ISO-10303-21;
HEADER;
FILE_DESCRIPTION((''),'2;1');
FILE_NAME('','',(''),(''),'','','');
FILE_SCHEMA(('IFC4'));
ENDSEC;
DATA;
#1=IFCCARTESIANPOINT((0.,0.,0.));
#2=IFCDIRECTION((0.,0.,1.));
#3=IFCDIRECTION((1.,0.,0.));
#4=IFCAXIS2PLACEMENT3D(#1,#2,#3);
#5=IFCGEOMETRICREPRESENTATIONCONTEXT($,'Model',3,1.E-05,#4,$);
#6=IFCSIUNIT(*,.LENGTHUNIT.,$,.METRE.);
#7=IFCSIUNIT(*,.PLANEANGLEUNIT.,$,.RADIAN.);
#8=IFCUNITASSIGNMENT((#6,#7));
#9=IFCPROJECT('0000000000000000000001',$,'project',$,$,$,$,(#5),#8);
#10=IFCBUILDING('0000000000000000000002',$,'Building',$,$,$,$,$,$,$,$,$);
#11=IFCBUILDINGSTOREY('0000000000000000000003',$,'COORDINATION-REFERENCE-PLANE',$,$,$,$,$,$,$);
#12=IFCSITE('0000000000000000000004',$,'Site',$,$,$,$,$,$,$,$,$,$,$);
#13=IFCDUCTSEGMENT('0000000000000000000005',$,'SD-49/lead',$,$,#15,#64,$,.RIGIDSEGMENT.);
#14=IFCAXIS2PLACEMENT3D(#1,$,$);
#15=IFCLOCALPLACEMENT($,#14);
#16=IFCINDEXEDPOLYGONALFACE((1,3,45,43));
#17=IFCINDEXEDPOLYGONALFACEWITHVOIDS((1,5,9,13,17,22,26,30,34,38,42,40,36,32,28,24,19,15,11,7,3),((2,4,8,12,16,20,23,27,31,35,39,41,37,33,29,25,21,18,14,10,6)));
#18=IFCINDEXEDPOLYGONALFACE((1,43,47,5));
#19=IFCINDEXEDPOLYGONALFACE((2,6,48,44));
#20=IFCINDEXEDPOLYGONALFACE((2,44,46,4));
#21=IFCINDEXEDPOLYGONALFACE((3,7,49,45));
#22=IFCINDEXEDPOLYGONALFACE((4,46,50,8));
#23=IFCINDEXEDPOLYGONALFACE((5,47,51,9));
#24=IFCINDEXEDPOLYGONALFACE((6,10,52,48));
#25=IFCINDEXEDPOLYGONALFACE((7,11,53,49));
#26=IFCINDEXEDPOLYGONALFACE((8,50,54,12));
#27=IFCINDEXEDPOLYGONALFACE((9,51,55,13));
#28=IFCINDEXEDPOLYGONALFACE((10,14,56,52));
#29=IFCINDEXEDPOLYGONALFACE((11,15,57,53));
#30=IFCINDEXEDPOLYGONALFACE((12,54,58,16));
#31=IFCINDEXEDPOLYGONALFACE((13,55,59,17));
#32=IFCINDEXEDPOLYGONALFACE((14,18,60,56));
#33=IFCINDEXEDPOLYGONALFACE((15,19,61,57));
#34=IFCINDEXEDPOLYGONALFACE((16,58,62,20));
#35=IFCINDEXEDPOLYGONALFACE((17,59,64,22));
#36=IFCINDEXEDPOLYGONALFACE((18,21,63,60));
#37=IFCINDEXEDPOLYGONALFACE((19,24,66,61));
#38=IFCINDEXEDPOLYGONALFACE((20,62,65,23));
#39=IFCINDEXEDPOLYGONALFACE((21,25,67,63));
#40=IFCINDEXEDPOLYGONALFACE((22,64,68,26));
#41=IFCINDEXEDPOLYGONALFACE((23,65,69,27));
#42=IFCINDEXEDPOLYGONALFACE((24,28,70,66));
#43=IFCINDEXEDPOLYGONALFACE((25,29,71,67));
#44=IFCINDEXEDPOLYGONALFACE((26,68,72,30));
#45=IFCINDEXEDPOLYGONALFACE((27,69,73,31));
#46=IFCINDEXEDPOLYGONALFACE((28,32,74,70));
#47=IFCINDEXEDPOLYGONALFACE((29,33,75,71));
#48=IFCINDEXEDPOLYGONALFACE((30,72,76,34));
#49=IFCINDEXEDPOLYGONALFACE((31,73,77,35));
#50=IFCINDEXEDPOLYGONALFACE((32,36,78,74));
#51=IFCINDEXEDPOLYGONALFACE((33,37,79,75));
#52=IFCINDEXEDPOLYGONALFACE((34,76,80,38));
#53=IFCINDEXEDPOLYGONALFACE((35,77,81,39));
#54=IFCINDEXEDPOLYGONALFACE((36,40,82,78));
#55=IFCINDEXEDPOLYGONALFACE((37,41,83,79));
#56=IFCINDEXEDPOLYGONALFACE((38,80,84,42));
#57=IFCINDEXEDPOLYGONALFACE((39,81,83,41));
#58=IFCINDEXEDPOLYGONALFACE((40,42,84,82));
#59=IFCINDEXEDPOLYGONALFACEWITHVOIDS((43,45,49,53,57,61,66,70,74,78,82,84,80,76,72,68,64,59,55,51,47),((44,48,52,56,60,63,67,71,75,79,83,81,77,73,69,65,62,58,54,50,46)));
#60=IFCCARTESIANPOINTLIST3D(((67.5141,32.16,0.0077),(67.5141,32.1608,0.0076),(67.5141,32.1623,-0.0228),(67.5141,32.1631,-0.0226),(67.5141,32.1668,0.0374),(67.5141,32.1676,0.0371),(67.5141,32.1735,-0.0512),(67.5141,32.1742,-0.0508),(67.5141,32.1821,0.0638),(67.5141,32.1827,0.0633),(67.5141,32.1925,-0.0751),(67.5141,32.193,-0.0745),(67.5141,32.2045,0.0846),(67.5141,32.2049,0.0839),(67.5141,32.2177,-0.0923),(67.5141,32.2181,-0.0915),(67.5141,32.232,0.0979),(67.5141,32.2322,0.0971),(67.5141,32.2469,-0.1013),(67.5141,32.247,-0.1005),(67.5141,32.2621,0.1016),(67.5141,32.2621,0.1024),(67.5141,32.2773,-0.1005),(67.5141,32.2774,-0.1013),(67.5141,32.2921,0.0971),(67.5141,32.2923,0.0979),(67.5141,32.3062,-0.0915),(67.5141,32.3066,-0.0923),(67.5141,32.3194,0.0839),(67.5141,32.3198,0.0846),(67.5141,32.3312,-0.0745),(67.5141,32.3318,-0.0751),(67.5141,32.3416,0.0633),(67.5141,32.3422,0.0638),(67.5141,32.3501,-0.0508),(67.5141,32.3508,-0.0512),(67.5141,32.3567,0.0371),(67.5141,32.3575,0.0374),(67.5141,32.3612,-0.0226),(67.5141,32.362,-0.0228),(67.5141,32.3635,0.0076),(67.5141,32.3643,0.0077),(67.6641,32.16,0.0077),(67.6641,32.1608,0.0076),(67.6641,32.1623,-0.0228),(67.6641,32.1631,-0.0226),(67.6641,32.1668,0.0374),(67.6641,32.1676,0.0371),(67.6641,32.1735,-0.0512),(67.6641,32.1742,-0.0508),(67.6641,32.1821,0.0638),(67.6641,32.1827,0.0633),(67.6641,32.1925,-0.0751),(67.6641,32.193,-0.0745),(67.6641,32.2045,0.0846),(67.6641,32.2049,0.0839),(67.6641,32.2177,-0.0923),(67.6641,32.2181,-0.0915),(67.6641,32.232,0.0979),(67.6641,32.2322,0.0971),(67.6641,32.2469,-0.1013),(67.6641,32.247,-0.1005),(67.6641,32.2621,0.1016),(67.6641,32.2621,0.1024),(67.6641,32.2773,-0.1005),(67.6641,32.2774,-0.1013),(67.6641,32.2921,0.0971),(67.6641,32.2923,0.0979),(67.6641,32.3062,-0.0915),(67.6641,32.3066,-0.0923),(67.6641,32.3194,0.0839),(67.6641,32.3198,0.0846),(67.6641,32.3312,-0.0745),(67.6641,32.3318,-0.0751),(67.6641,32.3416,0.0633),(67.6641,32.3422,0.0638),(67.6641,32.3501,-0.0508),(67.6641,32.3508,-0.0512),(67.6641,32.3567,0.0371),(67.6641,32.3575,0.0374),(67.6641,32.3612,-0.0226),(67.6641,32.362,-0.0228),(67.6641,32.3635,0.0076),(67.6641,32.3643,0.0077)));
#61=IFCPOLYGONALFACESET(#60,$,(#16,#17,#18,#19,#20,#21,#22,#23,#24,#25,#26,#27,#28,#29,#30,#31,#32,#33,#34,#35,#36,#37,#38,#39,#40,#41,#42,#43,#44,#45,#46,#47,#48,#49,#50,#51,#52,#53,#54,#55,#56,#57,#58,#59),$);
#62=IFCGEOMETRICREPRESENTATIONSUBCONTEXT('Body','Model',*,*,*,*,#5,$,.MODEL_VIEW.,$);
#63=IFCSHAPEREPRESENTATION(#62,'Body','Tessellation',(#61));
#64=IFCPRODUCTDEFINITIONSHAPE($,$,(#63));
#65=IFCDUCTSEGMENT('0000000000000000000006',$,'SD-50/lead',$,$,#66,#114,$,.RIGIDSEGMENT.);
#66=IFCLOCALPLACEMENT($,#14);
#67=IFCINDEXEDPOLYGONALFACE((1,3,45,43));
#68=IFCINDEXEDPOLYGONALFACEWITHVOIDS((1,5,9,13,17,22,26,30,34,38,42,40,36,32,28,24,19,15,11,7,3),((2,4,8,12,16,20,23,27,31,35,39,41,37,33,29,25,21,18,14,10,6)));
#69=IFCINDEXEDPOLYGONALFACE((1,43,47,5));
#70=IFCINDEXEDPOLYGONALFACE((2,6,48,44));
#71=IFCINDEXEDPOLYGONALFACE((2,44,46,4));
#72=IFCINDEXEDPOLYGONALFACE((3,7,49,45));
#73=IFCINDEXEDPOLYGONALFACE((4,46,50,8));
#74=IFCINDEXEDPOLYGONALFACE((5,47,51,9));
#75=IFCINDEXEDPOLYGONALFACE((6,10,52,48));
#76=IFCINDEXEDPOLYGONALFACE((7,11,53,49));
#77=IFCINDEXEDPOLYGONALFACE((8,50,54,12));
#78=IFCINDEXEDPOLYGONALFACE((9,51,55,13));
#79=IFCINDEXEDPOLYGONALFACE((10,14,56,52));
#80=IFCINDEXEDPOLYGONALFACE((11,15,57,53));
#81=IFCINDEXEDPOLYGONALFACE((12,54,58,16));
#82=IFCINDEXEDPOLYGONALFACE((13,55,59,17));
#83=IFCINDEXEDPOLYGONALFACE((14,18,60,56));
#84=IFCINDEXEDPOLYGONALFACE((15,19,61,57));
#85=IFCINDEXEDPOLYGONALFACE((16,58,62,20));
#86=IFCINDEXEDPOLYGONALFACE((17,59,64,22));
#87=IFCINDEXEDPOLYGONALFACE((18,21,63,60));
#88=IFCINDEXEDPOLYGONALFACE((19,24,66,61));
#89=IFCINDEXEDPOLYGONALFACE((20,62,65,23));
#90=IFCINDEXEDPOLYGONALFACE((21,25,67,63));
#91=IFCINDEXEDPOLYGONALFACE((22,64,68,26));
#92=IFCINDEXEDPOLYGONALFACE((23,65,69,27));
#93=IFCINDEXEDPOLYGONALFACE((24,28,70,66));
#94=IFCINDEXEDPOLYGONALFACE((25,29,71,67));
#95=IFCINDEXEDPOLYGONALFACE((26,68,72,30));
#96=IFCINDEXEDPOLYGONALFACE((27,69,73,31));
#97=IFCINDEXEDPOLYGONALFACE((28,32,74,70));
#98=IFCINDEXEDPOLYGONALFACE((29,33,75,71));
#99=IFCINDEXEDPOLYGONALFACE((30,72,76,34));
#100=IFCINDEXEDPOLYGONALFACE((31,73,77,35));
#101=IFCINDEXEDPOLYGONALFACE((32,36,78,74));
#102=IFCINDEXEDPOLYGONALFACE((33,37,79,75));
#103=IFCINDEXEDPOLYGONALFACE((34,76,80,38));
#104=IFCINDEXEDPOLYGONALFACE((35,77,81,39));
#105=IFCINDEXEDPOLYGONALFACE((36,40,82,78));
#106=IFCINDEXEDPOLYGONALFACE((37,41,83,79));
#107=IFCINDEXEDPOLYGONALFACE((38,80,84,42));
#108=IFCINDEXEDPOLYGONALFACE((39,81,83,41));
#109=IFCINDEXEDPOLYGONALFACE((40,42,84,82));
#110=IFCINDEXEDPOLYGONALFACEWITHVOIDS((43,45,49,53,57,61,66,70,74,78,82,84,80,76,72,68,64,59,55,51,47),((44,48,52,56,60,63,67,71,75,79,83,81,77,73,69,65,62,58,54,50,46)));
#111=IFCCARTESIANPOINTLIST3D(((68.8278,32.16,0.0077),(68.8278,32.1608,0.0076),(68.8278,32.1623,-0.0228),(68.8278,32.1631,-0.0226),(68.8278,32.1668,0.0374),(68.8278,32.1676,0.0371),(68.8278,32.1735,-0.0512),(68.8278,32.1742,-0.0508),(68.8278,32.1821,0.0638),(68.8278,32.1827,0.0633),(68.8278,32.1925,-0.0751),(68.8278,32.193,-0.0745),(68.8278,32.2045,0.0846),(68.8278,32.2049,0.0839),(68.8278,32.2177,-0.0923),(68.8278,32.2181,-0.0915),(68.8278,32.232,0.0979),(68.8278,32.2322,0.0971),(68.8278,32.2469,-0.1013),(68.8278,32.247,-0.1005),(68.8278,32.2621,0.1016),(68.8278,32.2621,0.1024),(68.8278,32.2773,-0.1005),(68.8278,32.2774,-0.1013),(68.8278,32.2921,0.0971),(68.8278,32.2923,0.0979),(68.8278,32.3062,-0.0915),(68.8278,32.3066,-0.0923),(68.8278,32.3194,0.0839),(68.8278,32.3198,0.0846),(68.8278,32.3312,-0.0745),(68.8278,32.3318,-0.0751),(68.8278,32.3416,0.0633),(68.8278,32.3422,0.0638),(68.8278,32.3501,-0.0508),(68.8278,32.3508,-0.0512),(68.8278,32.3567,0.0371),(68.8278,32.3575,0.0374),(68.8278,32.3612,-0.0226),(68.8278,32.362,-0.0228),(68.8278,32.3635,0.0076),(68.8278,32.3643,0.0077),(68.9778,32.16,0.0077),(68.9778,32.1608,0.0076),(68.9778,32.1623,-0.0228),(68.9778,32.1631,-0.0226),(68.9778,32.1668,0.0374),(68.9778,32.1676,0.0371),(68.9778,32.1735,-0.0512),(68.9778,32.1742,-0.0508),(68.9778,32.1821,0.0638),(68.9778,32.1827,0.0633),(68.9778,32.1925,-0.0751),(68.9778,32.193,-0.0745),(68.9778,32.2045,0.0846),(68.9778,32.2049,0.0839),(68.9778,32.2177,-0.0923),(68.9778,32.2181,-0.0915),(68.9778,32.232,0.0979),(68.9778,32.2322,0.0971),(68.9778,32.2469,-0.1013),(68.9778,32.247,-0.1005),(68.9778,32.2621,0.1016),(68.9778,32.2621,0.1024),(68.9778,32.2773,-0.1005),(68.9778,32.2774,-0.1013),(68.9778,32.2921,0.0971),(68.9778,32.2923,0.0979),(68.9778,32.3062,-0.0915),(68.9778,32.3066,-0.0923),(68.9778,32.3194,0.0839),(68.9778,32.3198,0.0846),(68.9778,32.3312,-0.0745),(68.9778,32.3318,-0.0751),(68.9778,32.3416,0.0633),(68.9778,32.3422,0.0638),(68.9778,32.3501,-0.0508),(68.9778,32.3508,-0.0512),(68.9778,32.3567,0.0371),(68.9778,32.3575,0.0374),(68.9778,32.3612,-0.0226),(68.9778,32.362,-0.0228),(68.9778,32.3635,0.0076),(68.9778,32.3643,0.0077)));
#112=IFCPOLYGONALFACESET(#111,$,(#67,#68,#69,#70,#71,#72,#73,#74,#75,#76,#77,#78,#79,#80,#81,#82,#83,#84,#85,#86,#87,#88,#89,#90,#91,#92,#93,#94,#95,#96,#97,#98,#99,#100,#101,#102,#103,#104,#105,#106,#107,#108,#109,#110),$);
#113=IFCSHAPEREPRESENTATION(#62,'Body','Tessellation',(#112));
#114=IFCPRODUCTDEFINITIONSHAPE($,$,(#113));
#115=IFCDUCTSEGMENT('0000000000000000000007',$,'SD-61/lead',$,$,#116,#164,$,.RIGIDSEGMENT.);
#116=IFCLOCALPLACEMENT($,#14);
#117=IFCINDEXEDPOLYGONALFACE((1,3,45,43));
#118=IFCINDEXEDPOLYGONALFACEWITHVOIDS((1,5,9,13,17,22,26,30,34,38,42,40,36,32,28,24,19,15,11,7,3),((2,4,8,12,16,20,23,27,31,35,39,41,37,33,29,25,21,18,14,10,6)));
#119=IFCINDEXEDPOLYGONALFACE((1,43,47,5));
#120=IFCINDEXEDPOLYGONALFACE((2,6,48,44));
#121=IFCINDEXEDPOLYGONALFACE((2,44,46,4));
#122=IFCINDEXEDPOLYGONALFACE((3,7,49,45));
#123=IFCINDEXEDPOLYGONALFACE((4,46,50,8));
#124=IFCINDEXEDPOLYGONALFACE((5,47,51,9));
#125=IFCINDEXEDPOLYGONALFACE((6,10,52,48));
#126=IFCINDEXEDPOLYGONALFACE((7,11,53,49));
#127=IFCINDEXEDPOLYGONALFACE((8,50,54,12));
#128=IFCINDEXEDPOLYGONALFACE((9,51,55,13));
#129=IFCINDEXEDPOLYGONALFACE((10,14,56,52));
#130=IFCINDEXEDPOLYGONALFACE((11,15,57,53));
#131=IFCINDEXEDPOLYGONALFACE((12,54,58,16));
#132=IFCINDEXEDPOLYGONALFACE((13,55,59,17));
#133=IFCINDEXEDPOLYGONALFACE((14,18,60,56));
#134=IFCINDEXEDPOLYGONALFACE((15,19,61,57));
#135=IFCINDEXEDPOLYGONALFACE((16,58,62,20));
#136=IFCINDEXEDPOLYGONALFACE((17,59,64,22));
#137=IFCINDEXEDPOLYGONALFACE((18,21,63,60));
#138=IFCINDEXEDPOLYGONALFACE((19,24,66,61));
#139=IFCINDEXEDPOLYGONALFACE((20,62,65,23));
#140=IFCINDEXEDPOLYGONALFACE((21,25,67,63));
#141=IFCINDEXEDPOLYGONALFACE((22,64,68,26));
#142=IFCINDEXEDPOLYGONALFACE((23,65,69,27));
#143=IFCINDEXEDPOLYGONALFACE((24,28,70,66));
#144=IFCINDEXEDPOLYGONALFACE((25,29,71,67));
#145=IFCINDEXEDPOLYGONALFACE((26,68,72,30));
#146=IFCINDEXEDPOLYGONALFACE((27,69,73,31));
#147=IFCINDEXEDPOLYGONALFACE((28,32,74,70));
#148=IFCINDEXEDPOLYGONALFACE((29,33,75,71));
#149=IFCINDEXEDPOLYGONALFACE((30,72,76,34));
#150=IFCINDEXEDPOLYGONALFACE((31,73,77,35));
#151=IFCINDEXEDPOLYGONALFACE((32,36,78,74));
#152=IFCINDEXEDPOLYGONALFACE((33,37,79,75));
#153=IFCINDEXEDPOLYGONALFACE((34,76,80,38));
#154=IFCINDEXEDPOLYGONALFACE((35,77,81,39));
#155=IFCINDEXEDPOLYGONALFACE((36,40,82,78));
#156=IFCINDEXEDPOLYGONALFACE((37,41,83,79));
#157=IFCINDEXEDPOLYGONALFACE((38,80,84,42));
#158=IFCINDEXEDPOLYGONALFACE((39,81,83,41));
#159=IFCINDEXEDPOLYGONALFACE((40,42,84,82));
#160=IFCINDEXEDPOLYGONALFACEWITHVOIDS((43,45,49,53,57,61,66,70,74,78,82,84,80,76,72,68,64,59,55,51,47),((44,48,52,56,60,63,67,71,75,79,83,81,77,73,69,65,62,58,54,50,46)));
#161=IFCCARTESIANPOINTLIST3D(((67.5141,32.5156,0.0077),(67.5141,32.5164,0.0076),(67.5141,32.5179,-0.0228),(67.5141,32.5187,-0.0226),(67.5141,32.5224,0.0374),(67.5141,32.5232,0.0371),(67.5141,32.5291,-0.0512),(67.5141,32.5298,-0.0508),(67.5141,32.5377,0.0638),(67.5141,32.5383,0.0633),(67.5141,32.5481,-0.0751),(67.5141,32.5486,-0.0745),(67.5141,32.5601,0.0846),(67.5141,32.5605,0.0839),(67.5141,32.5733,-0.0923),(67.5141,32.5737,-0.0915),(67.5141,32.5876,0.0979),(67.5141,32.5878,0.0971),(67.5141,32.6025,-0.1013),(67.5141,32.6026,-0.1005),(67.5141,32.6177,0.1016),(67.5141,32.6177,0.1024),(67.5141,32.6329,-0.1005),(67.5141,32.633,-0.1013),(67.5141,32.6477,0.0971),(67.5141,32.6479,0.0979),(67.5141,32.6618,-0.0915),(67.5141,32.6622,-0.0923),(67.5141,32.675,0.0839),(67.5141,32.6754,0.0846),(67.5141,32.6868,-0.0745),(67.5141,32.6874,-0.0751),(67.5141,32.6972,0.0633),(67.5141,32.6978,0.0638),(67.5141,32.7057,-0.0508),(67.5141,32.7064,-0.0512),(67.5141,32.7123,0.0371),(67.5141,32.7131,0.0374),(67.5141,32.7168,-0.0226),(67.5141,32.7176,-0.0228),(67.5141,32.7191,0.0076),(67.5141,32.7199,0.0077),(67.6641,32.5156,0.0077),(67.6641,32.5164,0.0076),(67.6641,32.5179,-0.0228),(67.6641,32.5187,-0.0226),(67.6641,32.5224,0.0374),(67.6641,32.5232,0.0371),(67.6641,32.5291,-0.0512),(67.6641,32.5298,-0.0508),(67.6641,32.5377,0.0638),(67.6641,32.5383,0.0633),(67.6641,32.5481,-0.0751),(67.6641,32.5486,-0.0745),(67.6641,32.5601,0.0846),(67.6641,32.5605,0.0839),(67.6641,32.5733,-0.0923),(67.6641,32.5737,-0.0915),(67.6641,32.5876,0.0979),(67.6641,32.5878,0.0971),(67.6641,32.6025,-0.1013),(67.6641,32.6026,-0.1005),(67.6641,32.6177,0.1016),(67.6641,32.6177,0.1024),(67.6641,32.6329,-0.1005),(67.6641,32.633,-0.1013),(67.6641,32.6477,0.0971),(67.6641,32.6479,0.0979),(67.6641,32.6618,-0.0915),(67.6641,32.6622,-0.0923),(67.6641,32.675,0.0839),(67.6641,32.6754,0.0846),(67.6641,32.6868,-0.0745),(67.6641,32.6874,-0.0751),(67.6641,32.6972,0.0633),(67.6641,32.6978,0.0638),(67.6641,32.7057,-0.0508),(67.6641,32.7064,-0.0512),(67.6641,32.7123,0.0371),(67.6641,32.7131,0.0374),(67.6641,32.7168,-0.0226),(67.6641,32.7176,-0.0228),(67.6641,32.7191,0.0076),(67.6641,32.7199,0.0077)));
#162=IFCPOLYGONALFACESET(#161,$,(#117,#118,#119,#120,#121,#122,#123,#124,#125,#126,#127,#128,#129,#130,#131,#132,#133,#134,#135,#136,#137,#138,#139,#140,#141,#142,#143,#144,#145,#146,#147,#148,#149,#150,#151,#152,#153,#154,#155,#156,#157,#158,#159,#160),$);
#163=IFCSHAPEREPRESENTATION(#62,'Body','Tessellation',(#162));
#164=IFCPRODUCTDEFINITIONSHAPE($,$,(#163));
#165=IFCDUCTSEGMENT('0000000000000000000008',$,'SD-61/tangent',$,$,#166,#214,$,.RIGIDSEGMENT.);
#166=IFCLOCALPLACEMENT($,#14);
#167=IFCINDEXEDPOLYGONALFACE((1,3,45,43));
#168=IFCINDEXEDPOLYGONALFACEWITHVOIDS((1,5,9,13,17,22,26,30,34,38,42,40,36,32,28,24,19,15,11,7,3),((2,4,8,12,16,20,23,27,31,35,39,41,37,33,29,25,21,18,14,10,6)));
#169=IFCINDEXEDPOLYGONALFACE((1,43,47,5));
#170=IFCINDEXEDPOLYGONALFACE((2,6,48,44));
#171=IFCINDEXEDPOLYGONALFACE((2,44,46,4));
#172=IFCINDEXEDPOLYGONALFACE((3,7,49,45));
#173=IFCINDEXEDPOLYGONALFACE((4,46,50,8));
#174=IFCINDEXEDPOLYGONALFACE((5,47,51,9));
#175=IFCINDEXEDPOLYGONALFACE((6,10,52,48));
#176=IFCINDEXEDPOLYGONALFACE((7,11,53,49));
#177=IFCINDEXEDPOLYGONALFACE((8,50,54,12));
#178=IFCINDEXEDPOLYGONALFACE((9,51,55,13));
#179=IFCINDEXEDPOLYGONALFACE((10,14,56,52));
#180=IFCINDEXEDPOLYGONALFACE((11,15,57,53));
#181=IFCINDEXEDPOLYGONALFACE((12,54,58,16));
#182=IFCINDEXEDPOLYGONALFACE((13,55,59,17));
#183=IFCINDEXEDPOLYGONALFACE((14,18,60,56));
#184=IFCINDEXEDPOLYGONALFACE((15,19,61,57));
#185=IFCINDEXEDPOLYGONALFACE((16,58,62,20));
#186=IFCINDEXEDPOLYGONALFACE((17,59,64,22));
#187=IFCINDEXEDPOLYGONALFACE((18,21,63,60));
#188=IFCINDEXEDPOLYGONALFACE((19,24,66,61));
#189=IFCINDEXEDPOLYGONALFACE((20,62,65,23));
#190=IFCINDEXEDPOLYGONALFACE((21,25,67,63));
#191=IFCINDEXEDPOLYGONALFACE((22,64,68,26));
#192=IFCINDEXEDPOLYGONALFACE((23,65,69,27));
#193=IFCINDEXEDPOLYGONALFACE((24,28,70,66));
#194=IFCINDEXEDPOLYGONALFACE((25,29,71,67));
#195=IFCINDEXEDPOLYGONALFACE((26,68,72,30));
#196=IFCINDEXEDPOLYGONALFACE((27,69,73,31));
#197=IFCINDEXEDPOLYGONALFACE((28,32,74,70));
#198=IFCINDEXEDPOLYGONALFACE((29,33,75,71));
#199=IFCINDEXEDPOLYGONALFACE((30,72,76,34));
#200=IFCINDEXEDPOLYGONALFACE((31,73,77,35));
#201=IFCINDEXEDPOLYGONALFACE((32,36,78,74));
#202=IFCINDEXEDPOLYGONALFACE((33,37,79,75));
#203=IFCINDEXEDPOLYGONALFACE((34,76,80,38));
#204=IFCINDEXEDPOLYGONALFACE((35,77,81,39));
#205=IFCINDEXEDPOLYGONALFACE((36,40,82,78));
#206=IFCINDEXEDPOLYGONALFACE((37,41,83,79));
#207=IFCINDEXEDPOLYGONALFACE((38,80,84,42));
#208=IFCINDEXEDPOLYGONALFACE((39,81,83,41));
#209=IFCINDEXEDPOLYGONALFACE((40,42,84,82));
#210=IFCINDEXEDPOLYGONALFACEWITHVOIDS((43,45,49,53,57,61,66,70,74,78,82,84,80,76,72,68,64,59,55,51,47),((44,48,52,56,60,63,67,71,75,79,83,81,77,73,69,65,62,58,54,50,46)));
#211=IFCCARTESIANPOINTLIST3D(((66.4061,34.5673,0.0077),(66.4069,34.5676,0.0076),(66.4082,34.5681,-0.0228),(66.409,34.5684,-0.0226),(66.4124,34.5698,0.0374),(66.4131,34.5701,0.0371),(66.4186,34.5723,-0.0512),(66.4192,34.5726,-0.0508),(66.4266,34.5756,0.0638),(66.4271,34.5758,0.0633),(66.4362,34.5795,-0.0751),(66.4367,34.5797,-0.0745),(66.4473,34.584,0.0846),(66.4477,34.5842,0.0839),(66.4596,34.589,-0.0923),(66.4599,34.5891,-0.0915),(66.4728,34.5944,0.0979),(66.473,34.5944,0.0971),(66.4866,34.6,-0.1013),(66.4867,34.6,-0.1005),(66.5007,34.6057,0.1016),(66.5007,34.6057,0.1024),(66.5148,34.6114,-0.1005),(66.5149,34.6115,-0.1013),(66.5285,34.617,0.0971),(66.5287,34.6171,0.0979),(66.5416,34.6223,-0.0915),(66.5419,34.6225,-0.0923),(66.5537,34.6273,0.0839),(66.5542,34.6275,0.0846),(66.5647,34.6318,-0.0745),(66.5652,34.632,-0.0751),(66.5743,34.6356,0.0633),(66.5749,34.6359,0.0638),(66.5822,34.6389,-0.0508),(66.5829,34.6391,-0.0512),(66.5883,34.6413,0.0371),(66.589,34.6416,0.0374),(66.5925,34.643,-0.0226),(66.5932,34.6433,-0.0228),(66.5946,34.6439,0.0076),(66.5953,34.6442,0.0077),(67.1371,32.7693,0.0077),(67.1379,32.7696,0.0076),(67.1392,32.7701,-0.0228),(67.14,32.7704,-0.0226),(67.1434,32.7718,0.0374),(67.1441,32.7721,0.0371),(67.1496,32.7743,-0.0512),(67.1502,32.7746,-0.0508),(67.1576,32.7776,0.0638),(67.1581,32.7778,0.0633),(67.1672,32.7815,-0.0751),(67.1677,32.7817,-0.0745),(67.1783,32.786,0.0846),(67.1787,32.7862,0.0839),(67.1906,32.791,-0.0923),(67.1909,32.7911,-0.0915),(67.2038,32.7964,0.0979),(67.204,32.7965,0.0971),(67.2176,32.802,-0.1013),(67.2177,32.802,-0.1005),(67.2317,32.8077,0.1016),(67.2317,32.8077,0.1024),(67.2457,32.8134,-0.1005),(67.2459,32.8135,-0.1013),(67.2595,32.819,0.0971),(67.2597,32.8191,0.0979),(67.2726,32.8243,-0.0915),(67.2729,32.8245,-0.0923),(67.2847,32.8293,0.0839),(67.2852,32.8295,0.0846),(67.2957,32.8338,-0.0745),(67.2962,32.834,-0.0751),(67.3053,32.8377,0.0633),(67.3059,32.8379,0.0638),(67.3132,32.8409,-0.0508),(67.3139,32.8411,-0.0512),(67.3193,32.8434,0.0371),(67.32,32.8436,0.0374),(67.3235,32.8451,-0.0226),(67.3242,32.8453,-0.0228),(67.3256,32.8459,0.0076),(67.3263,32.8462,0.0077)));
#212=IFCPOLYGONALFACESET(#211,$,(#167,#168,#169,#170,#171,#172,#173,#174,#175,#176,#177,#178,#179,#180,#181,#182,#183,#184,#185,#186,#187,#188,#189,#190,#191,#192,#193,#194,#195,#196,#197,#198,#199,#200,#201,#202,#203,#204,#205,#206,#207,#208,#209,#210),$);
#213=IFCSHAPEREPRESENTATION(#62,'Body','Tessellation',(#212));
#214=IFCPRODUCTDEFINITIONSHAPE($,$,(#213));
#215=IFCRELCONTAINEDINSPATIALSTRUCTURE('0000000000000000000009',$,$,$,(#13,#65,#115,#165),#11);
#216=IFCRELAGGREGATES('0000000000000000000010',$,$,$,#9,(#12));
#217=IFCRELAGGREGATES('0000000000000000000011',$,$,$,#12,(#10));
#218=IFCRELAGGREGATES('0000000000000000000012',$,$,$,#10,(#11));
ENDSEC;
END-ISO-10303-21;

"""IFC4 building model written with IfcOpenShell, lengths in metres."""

from ifc_helpers import new_model, si_unit, frame, origin_with_axes, place, context, subcontext, project, spatial, hollow_circle, extrude, element, save


model = new_model("IFC4")

# Units and contexts
model_context = context("Model", 3, precision=1e-05, world=origin_with_axes())
body_context_1 = subcontext(model_context, "Body", "Model", "MODEL_VIEW")
ifc_project = project(units=[si_unit("LENGTHUNIT", "METRE"), si_unit("PLANEANGLEUNIT", "RADIAN")], contexts=[model_context])

# Site, building, storey
site = spatial("IfcSite", under=ifc_project, Name="Site")
building = spatial("IfcBuilding", under=site, Name="Building")
storey = spatial("IfcBuildingStorey", under=building, Name="COORDINATION-REFERENCE-PLANE")

# Duct segments
for number, where, z_axis, x_axis, name in (
    (1, (67.6641, 32.2621, 0.0), (-1.0, 0.0, 0.0), (0.0, 0.0, 1.0), "SD-49/lead"),
    (2, (68.8278, 32.2621, 0.0), (1.0, 0.0, 0.0), (0.0, 0.0, 1.0), "SD-50/lead"),
    (3, (67.6641, 32.6177, 0.0), (-1.0, 0.0, 0.0), (0.0, 0.0, 1.0), "SD-61/lead"),
):
    element("IfcDuctSegment", number, at=place(None, frame(where, z_axis=z_axis, x_axis=x_axis)), inside=storey, Name=name, PredefinedType="RIGIDSEGMENT", context=body_context_1, shape_type="SweptSolid", body=[
        extrude(hollow_circle(Radius=0.1024, WallThickness=0.0008), origin_with_axes(), (0.0, 0.0, 1.0), 0.15),
    ])

# Duct segment
duct_segment_1_placement = place(None, frame((67.2317, 32.8077, 0.0), z_axis=(-0.376625, 0.926366, 0.0), x_axis=(0.0, 0.0, 1.0)))
element("IfcDuctSegment", 4, at=duct_segment_1_placement, inside=storey, Name="SD-61/tangent", PredefinedType="RIGIDSEGMENT", context=body_context_1, shape_type="SweptSolid", body=[
    extrude(hollow_circle(Radius=0.1024, WallThickness=0.0008), origin_with_axes(), (0.0, 0.0, 1.0), 1.9409),
])

save(model, "model.ifc")
